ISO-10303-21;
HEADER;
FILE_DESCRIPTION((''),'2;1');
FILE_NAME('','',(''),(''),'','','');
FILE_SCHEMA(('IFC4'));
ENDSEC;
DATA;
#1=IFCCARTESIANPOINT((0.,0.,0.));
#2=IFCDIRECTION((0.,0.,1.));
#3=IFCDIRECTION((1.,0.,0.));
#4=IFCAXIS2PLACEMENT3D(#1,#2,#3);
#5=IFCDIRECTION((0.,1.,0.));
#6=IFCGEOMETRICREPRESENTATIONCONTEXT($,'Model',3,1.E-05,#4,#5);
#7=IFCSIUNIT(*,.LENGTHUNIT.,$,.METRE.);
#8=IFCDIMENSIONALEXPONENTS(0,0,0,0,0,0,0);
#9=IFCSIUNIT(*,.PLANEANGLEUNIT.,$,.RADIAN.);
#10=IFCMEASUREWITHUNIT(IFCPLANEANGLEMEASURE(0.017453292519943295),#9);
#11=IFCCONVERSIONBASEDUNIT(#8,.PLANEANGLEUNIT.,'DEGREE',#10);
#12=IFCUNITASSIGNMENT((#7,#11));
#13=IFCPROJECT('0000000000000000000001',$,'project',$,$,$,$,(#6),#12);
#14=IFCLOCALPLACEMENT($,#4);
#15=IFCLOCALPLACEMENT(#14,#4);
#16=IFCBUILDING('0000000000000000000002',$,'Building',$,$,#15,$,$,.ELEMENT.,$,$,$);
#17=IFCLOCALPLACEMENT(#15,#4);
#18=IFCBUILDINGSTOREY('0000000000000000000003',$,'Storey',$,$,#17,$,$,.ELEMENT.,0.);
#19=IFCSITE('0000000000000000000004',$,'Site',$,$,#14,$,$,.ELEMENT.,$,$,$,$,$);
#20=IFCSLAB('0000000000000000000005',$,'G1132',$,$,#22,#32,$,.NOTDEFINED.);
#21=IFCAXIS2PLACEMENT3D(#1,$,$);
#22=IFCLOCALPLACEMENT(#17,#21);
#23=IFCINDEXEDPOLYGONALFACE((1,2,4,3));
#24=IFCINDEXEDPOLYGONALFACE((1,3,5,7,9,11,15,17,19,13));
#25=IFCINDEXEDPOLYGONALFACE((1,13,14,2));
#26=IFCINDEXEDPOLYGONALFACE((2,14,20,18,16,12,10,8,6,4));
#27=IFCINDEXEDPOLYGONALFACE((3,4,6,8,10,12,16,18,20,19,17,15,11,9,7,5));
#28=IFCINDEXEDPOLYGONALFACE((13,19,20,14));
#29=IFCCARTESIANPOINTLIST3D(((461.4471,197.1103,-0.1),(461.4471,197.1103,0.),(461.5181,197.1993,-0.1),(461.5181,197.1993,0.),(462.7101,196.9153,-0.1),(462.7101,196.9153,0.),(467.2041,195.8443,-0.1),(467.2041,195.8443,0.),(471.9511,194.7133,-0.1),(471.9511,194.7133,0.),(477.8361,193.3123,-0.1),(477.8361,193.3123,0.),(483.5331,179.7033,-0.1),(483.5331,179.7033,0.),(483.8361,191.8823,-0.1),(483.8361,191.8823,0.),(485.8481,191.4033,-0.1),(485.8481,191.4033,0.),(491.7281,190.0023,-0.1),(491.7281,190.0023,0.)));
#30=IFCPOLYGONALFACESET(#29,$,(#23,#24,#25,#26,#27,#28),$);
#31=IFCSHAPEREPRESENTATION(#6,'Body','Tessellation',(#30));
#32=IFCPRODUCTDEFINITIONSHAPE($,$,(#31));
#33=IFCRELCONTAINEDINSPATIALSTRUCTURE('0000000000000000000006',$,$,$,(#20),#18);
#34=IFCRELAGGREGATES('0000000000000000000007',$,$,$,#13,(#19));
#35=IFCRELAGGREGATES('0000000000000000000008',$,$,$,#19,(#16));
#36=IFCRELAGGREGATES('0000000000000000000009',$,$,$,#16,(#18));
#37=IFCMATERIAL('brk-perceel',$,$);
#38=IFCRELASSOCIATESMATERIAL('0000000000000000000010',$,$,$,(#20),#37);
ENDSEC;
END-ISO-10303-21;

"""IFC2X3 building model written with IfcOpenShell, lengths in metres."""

from ifc_helpers import new_model, entity, si_unit, converted_unit, direction, frame, origin_with_axes, place, context, project, spatial, polyline, outline, extrude, material, element, save


model = new_model("IFC2X3")

# Units and contexts
model_context = context("Model", 3, precision=1e-05, world=origin_with_axes(), true_north=direction((0.0, 1.0, 0.0)))
ifc_project = project(units=[si_unit("LENGTHUNIT", "METRE"), converted_unit("PLANEANGLEUNIT", "DEGREE", entity("IfcPlaneAngleMeasure", 0.017453292519943295), si_unit("PLANEANGLEUNIT", "RADIAN"), dimensions=[0, 0, 0, 0, 0, 0, 0])], contexts=[model_context])

# Site, building, storey
site_placement = place(None, origin_with_axes())
site = spatial("IfcSite", under=ifc_project, at=site_placement, Name="Site", CompositionType="ELEMENT")
building_placement = place(site_placement, origin_with_axes())
building = spatial("IfcBuilding", under=site, at=building_placement, Name="Building", CompositionType="ELEMENT")
storey_placement = place(building_placement, origin_with_axes())
storey = spatial("IfcBuildingStorey", under=building, at=storey_placement, Name="Storey", CompositionType="ELEMENT", Elevation=0.0)

# Slab
ifc_material = material(Name="brk-perceel")
slab_1_placement = place(storey_placement, frame((0.0, 0.0, -0.1), z_axis=(0.0, 0.0, 1.0), x_axis=(1.0, 0.0, 0.0)))
element("IfcSlab", 1, at=slab_1_placement, inside=storey, material=ifc_material, Name="G1132", PredefinedType="NOTDEFINED", context=model_context, shape_type="SweptSolid", body=[
    extrude(outline(polyline([(461.5181, 197.1993), (462.7101, 196.9153), (467.2041, 195.8443), (471.9511, 194.7133), (477.8361, 193.3123), (483.8361, 191.8823), (485.8481, 191.4033), (491.7281, 190.0023), (483.5331, 179.7033), (461.4471, 197.1103), (461.5181, 197.1993)])), origin_with_axes(), (0.0, 0.0, 1.0), 0.1),
])

save(model, "model.ifc")
